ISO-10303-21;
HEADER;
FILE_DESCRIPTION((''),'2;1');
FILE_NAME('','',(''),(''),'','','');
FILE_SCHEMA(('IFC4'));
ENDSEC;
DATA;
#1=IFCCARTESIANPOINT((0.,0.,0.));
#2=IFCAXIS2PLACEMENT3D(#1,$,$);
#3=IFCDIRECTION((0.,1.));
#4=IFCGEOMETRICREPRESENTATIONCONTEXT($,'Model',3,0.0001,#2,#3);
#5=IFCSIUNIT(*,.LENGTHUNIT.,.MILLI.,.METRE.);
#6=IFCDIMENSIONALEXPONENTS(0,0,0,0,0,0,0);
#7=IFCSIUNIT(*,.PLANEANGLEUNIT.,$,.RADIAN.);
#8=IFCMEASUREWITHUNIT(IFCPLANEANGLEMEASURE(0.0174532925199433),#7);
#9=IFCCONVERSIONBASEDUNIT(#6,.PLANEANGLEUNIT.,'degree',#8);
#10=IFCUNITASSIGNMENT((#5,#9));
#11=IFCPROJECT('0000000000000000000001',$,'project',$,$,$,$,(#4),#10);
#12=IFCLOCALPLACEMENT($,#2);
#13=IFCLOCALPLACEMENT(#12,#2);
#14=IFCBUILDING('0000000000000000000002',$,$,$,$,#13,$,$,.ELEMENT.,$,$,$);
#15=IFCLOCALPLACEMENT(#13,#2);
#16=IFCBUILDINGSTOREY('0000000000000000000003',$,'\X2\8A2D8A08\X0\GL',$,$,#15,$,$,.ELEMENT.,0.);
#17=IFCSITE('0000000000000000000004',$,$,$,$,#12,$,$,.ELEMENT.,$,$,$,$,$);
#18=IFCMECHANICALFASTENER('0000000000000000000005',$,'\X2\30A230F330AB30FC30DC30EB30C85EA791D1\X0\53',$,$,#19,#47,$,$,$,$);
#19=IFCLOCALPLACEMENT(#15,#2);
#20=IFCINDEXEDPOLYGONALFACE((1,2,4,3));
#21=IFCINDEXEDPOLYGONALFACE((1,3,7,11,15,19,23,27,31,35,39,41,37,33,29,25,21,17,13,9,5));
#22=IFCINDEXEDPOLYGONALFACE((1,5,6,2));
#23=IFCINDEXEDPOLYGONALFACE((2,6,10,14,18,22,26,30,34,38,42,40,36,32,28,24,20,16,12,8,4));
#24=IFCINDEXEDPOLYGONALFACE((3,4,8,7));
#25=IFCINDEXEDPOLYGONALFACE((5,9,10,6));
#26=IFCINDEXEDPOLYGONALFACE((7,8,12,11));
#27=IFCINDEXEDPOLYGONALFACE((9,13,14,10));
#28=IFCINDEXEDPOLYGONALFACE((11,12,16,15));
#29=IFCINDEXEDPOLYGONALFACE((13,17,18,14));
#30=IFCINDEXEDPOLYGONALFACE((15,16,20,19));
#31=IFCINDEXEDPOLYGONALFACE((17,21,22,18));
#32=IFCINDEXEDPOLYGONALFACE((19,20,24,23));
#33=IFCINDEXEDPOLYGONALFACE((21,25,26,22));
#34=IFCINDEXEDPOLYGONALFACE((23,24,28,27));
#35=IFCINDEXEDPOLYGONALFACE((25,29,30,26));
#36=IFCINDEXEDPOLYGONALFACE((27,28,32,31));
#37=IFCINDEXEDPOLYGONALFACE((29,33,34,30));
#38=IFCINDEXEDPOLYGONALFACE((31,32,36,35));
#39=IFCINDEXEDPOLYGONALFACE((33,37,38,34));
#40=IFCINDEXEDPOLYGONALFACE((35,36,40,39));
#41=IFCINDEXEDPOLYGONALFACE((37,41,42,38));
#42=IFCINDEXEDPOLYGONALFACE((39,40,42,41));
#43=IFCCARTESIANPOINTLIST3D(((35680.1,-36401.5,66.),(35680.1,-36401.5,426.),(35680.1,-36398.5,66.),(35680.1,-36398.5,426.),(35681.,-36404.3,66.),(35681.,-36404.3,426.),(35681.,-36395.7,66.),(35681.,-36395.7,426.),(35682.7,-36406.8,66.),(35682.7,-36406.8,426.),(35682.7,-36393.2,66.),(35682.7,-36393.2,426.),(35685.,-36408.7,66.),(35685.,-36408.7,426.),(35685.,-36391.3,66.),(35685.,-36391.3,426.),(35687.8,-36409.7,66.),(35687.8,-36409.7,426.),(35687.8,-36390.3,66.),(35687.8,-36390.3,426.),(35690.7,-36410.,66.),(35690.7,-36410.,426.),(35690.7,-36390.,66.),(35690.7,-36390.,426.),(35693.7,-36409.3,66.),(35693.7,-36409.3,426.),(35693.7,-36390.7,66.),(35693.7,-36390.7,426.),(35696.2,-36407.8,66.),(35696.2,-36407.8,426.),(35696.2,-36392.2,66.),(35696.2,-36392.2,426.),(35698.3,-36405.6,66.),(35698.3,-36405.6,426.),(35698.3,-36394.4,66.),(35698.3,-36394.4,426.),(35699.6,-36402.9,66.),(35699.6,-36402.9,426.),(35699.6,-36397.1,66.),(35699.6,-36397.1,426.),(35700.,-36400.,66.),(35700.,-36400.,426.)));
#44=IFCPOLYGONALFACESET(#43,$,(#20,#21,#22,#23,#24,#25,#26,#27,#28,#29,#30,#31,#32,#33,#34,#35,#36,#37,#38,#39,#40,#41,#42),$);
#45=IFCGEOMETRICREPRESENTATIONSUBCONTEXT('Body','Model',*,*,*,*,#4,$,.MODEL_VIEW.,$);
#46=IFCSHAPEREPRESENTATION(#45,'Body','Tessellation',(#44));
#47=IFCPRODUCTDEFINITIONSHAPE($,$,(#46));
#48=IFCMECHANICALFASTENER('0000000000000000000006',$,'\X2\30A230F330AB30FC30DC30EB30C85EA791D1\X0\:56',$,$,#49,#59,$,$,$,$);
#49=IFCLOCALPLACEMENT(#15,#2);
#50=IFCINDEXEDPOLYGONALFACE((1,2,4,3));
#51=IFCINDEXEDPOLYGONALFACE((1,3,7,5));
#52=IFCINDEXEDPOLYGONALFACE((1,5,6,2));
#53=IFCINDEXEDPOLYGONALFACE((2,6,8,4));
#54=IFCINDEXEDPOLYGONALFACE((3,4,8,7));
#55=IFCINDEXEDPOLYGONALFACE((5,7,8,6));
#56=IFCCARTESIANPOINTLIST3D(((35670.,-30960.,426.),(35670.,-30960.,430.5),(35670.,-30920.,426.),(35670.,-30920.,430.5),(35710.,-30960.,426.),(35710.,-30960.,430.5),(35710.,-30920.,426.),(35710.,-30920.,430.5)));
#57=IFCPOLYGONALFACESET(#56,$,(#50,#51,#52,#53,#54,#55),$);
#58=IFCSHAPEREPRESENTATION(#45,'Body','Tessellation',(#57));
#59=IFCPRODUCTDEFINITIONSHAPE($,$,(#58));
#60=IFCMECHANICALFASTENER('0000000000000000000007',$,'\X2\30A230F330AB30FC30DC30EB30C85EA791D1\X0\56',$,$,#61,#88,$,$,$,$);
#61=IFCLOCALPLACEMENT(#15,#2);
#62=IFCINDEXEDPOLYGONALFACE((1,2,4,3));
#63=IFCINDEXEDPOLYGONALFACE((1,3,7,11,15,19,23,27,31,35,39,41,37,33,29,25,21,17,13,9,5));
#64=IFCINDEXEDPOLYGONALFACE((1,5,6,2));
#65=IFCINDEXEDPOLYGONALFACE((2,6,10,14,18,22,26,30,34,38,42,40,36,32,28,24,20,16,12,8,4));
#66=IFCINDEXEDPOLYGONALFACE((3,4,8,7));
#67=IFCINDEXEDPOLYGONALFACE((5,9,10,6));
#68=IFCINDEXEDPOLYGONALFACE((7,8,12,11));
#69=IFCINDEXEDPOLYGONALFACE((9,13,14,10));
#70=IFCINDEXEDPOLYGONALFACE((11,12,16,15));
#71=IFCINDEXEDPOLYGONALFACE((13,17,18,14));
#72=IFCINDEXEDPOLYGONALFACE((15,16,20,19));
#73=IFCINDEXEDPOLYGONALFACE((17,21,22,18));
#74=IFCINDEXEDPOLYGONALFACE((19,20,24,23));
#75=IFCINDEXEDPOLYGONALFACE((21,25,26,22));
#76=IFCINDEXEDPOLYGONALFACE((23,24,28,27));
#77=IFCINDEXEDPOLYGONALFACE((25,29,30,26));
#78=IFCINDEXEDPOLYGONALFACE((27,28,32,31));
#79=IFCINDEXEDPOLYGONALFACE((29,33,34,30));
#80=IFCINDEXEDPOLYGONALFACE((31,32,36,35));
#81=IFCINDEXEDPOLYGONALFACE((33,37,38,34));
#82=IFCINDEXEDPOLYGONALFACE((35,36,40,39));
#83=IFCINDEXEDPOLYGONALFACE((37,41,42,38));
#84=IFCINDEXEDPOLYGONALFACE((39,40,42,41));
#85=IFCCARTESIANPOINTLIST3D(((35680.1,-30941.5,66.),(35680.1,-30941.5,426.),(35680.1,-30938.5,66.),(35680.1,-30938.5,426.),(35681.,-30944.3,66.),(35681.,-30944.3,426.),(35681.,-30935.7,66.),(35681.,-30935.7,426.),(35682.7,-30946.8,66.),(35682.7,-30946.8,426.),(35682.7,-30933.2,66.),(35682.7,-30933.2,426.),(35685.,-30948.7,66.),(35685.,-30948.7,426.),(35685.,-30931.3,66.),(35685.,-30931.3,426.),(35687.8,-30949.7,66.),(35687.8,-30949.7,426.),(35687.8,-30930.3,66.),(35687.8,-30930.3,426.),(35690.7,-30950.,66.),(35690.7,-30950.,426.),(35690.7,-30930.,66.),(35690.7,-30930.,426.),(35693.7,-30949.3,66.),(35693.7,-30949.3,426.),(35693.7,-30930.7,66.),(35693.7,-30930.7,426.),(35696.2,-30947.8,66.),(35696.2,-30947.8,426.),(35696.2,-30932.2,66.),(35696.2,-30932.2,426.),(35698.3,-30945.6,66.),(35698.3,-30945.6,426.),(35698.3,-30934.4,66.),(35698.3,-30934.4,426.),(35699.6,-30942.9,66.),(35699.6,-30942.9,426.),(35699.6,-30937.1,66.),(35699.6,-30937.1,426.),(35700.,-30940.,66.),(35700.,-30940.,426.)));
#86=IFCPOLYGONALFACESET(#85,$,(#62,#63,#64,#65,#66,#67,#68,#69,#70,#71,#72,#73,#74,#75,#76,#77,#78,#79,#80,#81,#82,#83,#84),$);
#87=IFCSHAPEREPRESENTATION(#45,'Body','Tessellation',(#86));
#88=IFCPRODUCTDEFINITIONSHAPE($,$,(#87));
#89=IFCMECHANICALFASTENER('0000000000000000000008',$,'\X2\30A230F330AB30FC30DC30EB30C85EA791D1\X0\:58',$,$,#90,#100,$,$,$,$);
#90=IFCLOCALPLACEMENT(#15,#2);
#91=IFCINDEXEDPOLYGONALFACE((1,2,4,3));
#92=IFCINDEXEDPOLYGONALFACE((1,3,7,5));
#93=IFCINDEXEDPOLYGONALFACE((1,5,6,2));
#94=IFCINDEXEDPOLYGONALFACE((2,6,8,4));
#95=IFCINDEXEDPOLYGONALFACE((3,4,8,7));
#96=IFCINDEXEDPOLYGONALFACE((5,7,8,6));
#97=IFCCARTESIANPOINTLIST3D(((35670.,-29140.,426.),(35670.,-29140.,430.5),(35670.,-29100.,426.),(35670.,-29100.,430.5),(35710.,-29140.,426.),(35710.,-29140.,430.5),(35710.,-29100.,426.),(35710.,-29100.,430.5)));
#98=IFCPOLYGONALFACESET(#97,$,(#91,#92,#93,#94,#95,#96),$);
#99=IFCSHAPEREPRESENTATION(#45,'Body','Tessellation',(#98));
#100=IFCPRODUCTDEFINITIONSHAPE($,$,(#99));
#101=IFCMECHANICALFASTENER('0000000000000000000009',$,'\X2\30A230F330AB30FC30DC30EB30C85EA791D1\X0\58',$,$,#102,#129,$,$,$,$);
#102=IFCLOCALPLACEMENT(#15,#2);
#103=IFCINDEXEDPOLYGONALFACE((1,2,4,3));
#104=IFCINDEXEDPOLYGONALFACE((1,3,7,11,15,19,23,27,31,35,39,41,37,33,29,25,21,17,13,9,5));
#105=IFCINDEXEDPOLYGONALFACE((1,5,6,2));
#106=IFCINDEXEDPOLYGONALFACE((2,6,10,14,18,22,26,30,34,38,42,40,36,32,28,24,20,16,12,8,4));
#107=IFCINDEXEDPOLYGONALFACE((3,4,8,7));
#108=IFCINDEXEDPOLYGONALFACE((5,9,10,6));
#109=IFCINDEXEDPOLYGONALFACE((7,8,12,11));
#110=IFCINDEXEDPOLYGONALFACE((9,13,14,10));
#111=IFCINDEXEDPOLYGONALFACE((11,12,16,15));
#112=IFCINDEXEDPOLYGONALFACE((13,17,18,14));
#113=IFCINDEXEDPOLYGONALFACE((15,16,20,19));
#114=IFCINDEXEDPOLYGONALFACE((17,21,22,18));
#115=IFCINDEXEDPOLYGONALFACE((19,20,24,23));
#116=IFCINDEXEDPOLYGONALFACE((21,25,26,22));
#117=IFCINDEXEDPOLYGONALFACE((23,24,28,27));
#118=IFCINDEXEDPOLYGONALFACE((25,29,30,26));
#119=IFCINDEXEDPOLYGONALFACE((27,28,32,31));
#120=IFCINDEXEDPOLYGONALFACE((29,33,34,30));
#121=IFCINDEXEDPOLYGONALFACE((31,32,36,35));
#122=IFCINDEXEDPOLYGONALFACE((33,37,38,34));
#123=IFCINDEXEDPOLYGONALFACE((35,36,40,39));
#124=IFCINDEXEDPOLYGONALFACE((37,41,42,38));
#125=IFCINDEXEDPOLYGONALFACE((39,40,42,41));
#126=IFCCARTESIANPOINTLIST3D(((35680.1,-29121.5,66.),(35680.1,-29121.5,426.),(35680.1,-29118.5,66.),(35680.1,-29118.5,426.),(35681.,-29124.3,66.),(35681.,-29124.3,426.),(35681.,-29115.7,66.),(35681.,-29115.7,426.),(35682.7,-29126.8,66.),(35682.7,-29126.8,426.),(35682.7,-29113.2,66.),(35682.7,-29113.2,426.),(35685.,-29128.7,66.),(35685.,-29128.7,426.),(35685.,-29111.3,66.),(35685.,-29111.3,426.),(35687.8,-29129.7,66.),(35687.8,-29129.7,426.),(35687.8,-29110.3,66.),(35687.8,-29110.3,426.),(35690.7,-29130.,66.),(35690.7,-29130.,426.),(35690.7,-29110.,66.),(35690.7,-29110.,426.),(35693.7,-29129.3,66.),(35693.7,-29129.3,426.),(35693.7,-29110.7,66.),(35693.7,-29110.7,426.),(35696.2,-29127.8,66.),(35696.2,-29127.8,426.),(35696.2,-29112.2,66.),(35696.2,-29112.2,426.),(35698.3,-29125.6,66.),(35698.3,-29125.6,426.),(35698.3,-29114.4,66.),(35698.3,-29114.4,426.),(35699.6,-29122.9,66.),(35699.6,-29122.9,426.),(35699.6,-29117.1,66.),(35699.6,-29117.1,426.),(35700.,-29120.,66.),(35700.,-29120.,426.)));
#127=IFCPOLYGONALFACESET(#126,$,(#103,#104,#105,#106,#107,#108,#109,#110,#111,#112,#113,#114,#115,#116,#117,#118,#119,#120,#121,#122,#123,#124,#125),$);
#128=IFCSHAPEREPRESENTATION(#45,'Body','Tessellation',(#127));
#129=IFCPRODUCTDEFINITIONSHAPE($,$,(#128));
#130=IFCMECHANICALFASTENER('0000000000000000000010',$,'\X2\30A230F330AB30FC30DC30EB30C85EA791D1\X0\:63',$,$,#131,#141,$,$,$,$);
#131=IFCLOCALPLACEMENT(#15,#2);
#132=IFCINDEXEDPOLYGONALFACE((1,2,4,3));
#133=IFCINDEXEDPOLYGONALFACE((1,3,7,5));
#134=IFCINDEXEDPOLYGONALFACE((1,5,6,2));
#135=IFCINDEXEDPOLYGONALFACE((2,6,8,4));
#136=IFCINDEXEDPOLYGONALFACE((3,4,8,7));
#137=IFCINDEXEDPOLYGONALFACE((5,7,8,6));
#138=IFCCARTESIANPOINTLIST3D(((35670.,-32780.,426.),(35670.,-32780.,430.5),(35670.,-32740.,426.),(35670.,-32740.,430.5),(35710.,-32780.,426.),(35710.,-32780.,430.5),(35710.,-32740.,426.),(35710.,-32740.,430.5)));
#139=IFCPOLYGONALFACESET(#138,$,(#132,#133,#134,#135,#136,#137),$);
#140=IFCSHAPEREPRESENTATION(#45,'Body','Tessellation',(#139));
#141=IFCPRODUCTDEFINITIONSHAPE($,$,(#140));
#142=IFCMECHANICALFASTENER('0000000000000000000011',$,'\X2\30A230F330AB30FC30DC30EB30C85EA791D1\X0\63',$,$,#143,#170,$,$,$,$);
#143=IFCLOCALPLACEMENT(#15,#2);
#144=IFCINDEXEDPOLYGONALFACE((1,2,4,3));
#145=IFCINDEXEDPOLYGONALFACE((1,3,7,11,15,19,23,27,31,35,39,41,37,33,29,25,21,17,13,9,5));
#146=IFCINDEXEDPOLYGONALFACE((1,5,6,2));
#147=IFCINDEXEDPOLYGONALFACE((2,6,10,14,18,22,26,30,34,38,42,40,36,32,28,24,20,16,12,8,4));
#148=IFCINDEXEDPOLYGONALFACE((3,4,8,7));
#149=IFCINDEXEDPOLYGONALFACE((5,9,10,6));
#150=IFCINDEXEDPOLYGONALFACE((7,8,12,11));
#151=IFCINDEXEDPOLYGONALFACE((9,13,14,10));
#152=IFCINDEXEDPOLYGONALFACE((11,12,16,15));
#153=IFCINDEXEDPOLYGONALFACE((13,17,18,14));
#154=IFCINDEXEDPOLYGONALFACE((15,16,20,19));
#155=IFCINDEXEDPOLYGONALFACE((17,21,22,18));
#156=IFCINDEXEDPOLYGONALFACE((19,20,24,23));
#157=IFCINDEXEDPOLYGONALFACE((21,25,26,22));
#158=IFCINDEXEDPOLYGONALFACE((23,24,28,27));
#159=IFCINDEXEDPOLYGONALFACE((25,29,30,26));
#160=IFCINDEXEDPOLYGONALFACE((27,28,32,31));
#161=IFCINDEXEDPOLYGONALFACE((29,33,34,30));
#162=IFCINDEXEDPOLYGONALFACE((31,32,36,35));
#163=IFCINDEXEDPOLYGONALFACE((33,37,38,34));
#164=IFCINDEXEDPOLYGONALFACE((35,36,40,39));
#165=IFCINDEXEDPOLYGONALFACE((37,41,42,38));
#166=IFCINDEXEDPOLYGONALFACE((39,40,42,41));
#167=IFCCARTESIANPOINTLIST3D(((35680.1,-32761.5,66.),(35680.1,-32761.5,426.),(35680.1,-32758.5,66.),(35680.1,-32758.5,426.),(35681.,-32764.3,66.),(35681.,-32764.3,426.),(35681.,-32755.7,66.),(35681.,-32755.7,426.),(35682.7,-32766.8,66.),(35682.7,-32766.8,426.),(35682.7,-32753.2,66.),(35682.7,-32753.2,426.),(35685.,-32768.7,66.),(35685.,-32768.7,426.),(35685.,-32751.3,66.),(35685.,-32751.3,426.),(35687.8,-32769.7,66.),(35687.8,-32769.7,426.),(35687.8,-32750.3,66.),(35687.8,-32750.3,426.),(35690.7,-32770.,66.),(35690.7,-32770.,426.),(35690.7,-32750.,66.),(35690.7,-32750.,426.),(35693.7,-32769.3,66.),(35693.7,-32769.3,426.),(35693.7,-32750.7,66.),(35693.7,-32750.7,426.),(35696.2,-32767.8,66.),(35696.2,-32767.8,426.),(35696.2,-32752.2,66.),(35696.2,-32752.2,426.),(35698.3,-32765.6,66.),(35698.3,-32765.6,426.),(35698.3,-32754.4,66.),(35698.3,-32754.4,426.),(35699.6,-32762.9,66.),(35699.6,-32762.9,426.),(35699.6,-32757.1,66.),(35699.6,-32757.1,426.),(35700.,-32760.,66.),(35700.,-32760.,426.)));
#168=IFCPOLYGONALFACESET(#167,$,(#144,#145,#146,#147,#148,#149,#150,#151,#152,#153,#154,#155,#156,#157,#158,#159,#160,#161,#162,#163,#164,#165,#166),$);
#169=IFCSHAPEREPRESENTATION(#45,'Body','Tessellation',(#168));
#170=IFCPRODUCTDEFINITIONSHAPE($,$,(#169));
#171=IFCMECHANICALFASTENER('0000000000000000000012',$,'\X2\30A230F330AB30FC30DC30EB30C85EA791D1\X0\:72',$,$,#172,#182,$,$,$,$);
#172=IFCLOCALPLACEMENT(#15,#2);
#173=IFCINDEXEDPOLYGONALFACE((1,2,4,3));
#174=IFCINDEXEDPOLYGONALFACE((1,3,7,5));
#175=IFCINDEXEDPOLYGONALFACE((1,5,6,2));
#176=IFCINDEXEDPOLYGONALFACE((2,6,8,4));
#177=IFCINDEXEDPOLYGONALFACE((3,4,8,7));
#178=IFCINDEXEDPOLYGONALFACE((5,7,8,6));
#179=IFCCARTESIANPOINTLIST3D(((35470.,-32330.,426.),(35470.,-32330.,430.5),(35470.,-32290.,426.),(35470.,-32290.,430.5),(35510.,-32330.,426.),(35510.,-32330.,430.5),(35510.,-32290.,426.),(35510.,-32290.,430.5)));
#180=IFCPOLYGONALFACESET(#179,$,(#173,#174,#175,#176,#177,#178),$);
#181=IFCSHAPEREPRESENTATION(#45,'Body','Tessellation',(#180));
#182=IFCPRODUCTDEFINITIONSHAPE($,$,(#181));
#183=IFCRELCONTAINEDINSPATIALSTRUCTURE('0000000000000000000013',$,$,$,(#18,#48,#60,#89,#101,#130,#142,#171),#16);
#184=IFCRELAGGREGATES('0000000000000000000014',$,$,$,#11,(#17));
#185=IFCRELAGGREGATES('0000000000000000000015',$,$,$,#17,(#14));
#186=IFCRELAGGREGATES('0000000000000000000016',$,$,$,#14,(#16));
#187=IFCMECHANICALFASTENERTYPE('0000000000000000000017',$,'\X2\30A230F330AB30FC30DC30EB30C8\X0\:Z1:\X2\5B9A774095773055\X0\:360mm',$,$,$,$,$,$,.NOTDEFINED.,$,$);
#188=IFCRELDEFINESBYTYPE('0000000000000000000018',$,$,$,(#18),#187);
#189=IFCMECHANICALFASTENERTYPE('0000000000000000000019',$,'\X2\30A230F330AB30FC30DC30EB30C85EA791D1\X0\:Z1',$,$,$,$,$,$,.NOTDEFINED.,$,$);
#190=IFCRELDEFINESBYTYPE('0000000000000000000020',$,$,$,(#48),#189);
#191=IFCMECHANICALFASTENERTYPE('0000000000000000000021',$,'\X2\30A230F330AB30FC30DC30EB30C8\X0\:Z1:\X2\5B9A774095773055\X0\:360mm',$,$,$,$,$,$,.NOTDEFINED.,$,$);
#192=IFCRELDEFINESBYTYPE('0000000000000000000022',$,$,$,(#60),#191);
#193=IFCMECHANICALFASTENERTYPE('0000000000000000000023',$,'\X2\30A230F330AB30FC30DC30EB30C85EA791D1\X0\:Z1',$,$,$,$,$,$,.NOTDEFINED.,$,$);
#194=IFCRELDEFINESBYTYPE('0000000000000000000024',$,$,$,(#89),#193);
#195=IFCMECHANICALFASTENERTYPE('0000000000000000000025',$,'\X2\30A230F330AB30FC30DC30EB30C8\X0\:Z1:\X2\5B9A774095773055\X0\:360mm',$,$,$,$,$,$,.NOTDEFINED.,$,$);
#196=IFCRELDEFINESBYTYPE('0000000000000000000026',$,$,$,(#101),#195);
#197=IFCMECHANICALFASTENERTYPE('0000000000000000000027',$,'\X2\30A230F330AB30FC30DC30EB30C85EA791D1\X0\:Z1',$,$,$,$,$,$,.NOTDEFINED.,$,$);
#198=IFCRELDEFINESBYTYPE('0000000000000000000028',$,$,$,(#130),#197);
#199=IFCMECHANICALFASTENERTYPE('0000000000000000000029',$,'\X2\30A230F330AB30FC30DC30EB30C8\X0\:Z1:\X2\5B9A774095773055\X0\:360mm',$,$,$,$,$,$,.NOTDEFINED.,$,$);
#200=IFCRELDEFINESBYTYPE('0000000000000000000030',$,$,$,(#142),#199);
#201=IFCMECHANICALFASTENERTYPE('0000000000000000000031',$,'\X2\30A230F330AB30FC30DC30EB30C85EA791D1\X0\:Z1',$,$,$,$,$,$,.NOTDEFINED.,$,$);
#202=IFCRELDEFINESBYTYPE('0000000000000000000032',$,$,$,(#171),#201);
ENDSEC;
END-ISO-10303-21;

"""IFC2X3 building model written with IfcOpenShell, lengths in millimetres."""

from ifc_helpers import new_model, entity, si_unit, converted_unit, direction, frame, origin, origin_with_axes, origin_2d, place, context, subcontext, project, spatial, rectangle, circle, extrude, type_object, element, save


model = new_model("IFC2X3")

# Units and contexts
model_context = context("Model", 3, precision=0.0001, world=origin(), true_north=direction((0.0, 1.0)))
body_context = subcontext(model_context, "Body", "Model", "MODEL_VIEW")
ifc_project = project(units=[si_unit("LENGTHUNIT", "METRE", prefix="MILLI"), converted_unit("PLANEANGLEUNIT", "degree", entity("IfcPlaneAngleMeasure", 0.0174532925199433), si_unit("PLANEANGLEUNIT", "RADIAN"), dimensions=[0, 0, 0, 0, 0, 0, 0])], contexts=[model_context])

# Site, building, storey
site_placement = place(None, origin())
site = spatial("IfcSite", under=ifc_project, at=site_placement, CompositionType="ELEMENT")
building_placement = place(site_placement, origin())
building = spatial("IfcBuilding", under=site, at=building_placement, CompositionType="ELEMENT")
storey_placement = place(building_placement, origin())
storey = spatial("IfcBuildingStorey", under=building, at=storey_placement, Name="設計GL", CompositionType="ELEMENT", Elevation=0.0)

# Mechanical fasteners
mechanical_fastener_type_1 = type_object("IfcMechanicalFastenerType", Name="アンカーボルト:Z1:定着長さ:360mm")
mechanical_fastener_1_placement = place(storey_placement, frame((35690.0, -36400.0, 66.0)))
element("IfcMechanicalFastener", 1, at=mechanical_fastener_1_placement, inside=storey, type_object=mechanical_fastener_type_1, Name="アンカーボルト座金53", context=body_context, shape_type="SweptSolid", body=[
    extrude(circle(Radius=10.0, at=origin_2d()), origin_with_axes(), (0.0, 0.0, 1.0), 360.0),
])
mechanical_fastener_type_2 = type_object("IfcMechanicalFastenerType", Name="アンカーボルト座金:Z1")
mechanical_fastener_2_placement = place(storey_placement, frame((35690.0, -30940.0, 426.0)))
element("IfcMechanicalFastener", 2, at=mechanical_fastener_2_placement, inside=storey, type_object=mechanical_fastener_type_2, Name="アンカーボルト座金:56", context=body_context, shape_type="SweptSolid", body=[
    extrude(rectangle(XDim=40.0, YDim=40.0, at=origin_2d()), origin_with_axes(), (0.0, 0.0, 1.0), 4.5),
])
mechanical_fastener_type_3 = type_object("IfcMechanicalFastenerType", Name="アンカーボルト:Z1:定着長さ:360mm")
mechanical_fastener_3_placement = place(storey_placement, frame((35690.0, -30940.0, 66.0)))
element("IfcMechanicalFastener", 3, at=mechanical_fastener_3_placement, inside=storey, type_object=mechanical_fastener_type_3, Name="アンカーボルト座金56", context=body_context, shape_type="SweptSolid", body=[
    extrude(circle(Radius=10.0, at=origin_2d()), origin_with_axes(), (0.0, 0.0, 1.0), 360.0),
])
mechanical_fastener_type_4 = type_object("IfcMechanicalFastenerType", Name="アンカーボルト座金:Z1")
mechanical_fastener_4_placement = place(storey_placement, frame((35690.0, -29120.0, 426.0)))
element("IfcMechanicalFastener", 4, at=mechanical_fastener_4_placement, inside=storey, type_object=mechanical_fastener_type_4, Name="アンカーボルト座金:58", context=body_context, shape_type="SweptSolid", body=[
    extrude(rectangle(XDim=40.0, YDim=40.0, at=origin_2d()), origin_with_axes(), (0.0, 0.0, 1.0), 4.5),
])
mechanical_fastener_type_5 = type_object("IfcMechanicalFastenerType", Name="アンカーボルト:Z1:定着長さ:360mm")
mechanical_fastener_5_placement = place(storey_placement, frame((35690.0, -29120.0, 66.0)))
element("IfcMechanicalFastener", 5, at=mechanical_fastener_5_placement, inside=storey, type_object=mechanical_fastener_type_5, Name="アンカーボルト座金58", context=body_context, shape_type="SweptSolid", body=[
    extrude(circle(Radius=10.0, at=origin_2d()), origin_with_axes(), (0.0, 0.0, 1.0), 360.0),
])
mechanical_fastener_type_6 = type_object("IfcMechanicalFastenerType", Name="アンカーボルト座金:Z1")
mechanical_fastener_6_placement = place(storey_placement, frame((35690.0, -32760.0, 426.0)))
element("IfcMechanicalFastener", 6, at=mechanical_fastener_6_placement, inside=storey, type_object=mechanical_fastener_type_6, Name="アンカーボルト座金:63", context=body_context, shape_type="SweptSolid", body=[
    extrude(rectangle(XDim=40.0, YDim=40.0, at=origin_2d()), origin_with_axes(), (0.0, 0.0, 1.0), 4.5),
])
mechanical_fastener_type_7 = type_object("IfcMechanicalFastenerType", Name="アンカーボルト:Z1:定着長さ:360mm")
mechanical_fastener_7_placement = place(storey_placement, frame((35690.0, -32760.0, 66.0)))
element("IfcMechanicalFastener", 7, at=mechanical_fastener_7_placement, inside=storey, type_object=mechanical_fastener_type_7, Name="アンカーボルト座金63", context=body_context, shape_type="SweptSolid", body=[
    extrude(circle(Radius=10.0, at=origin_2d()), origin_with_axes(), (0.0, 0.0, 1.0), 360.0),
])
mechanical_fastener_type_8 = type_object("IfcMechanicalFastenerType", Name="アンカーボルト座金:Z1")
mechanical_fastener_8_placement = place(storey_placement, frame((35490.0, -32310.0, 426.0)))
element("IfcMechanicalFastener", 8, at=mechanical_fastener_8_placement, inside=storey, type_object=mechanical_fastener_type_8, Name="アンカーボルト座金:72", context=body_context, shape_type="SweptSolid", body=[
    extrude(rectangle(XDim=40.0, YDim=40.0, at=origin_2d()), origin_with_axes(), (0.0, 0.0, 1.0), 4.5),
])

save(model, "model.ifc")
